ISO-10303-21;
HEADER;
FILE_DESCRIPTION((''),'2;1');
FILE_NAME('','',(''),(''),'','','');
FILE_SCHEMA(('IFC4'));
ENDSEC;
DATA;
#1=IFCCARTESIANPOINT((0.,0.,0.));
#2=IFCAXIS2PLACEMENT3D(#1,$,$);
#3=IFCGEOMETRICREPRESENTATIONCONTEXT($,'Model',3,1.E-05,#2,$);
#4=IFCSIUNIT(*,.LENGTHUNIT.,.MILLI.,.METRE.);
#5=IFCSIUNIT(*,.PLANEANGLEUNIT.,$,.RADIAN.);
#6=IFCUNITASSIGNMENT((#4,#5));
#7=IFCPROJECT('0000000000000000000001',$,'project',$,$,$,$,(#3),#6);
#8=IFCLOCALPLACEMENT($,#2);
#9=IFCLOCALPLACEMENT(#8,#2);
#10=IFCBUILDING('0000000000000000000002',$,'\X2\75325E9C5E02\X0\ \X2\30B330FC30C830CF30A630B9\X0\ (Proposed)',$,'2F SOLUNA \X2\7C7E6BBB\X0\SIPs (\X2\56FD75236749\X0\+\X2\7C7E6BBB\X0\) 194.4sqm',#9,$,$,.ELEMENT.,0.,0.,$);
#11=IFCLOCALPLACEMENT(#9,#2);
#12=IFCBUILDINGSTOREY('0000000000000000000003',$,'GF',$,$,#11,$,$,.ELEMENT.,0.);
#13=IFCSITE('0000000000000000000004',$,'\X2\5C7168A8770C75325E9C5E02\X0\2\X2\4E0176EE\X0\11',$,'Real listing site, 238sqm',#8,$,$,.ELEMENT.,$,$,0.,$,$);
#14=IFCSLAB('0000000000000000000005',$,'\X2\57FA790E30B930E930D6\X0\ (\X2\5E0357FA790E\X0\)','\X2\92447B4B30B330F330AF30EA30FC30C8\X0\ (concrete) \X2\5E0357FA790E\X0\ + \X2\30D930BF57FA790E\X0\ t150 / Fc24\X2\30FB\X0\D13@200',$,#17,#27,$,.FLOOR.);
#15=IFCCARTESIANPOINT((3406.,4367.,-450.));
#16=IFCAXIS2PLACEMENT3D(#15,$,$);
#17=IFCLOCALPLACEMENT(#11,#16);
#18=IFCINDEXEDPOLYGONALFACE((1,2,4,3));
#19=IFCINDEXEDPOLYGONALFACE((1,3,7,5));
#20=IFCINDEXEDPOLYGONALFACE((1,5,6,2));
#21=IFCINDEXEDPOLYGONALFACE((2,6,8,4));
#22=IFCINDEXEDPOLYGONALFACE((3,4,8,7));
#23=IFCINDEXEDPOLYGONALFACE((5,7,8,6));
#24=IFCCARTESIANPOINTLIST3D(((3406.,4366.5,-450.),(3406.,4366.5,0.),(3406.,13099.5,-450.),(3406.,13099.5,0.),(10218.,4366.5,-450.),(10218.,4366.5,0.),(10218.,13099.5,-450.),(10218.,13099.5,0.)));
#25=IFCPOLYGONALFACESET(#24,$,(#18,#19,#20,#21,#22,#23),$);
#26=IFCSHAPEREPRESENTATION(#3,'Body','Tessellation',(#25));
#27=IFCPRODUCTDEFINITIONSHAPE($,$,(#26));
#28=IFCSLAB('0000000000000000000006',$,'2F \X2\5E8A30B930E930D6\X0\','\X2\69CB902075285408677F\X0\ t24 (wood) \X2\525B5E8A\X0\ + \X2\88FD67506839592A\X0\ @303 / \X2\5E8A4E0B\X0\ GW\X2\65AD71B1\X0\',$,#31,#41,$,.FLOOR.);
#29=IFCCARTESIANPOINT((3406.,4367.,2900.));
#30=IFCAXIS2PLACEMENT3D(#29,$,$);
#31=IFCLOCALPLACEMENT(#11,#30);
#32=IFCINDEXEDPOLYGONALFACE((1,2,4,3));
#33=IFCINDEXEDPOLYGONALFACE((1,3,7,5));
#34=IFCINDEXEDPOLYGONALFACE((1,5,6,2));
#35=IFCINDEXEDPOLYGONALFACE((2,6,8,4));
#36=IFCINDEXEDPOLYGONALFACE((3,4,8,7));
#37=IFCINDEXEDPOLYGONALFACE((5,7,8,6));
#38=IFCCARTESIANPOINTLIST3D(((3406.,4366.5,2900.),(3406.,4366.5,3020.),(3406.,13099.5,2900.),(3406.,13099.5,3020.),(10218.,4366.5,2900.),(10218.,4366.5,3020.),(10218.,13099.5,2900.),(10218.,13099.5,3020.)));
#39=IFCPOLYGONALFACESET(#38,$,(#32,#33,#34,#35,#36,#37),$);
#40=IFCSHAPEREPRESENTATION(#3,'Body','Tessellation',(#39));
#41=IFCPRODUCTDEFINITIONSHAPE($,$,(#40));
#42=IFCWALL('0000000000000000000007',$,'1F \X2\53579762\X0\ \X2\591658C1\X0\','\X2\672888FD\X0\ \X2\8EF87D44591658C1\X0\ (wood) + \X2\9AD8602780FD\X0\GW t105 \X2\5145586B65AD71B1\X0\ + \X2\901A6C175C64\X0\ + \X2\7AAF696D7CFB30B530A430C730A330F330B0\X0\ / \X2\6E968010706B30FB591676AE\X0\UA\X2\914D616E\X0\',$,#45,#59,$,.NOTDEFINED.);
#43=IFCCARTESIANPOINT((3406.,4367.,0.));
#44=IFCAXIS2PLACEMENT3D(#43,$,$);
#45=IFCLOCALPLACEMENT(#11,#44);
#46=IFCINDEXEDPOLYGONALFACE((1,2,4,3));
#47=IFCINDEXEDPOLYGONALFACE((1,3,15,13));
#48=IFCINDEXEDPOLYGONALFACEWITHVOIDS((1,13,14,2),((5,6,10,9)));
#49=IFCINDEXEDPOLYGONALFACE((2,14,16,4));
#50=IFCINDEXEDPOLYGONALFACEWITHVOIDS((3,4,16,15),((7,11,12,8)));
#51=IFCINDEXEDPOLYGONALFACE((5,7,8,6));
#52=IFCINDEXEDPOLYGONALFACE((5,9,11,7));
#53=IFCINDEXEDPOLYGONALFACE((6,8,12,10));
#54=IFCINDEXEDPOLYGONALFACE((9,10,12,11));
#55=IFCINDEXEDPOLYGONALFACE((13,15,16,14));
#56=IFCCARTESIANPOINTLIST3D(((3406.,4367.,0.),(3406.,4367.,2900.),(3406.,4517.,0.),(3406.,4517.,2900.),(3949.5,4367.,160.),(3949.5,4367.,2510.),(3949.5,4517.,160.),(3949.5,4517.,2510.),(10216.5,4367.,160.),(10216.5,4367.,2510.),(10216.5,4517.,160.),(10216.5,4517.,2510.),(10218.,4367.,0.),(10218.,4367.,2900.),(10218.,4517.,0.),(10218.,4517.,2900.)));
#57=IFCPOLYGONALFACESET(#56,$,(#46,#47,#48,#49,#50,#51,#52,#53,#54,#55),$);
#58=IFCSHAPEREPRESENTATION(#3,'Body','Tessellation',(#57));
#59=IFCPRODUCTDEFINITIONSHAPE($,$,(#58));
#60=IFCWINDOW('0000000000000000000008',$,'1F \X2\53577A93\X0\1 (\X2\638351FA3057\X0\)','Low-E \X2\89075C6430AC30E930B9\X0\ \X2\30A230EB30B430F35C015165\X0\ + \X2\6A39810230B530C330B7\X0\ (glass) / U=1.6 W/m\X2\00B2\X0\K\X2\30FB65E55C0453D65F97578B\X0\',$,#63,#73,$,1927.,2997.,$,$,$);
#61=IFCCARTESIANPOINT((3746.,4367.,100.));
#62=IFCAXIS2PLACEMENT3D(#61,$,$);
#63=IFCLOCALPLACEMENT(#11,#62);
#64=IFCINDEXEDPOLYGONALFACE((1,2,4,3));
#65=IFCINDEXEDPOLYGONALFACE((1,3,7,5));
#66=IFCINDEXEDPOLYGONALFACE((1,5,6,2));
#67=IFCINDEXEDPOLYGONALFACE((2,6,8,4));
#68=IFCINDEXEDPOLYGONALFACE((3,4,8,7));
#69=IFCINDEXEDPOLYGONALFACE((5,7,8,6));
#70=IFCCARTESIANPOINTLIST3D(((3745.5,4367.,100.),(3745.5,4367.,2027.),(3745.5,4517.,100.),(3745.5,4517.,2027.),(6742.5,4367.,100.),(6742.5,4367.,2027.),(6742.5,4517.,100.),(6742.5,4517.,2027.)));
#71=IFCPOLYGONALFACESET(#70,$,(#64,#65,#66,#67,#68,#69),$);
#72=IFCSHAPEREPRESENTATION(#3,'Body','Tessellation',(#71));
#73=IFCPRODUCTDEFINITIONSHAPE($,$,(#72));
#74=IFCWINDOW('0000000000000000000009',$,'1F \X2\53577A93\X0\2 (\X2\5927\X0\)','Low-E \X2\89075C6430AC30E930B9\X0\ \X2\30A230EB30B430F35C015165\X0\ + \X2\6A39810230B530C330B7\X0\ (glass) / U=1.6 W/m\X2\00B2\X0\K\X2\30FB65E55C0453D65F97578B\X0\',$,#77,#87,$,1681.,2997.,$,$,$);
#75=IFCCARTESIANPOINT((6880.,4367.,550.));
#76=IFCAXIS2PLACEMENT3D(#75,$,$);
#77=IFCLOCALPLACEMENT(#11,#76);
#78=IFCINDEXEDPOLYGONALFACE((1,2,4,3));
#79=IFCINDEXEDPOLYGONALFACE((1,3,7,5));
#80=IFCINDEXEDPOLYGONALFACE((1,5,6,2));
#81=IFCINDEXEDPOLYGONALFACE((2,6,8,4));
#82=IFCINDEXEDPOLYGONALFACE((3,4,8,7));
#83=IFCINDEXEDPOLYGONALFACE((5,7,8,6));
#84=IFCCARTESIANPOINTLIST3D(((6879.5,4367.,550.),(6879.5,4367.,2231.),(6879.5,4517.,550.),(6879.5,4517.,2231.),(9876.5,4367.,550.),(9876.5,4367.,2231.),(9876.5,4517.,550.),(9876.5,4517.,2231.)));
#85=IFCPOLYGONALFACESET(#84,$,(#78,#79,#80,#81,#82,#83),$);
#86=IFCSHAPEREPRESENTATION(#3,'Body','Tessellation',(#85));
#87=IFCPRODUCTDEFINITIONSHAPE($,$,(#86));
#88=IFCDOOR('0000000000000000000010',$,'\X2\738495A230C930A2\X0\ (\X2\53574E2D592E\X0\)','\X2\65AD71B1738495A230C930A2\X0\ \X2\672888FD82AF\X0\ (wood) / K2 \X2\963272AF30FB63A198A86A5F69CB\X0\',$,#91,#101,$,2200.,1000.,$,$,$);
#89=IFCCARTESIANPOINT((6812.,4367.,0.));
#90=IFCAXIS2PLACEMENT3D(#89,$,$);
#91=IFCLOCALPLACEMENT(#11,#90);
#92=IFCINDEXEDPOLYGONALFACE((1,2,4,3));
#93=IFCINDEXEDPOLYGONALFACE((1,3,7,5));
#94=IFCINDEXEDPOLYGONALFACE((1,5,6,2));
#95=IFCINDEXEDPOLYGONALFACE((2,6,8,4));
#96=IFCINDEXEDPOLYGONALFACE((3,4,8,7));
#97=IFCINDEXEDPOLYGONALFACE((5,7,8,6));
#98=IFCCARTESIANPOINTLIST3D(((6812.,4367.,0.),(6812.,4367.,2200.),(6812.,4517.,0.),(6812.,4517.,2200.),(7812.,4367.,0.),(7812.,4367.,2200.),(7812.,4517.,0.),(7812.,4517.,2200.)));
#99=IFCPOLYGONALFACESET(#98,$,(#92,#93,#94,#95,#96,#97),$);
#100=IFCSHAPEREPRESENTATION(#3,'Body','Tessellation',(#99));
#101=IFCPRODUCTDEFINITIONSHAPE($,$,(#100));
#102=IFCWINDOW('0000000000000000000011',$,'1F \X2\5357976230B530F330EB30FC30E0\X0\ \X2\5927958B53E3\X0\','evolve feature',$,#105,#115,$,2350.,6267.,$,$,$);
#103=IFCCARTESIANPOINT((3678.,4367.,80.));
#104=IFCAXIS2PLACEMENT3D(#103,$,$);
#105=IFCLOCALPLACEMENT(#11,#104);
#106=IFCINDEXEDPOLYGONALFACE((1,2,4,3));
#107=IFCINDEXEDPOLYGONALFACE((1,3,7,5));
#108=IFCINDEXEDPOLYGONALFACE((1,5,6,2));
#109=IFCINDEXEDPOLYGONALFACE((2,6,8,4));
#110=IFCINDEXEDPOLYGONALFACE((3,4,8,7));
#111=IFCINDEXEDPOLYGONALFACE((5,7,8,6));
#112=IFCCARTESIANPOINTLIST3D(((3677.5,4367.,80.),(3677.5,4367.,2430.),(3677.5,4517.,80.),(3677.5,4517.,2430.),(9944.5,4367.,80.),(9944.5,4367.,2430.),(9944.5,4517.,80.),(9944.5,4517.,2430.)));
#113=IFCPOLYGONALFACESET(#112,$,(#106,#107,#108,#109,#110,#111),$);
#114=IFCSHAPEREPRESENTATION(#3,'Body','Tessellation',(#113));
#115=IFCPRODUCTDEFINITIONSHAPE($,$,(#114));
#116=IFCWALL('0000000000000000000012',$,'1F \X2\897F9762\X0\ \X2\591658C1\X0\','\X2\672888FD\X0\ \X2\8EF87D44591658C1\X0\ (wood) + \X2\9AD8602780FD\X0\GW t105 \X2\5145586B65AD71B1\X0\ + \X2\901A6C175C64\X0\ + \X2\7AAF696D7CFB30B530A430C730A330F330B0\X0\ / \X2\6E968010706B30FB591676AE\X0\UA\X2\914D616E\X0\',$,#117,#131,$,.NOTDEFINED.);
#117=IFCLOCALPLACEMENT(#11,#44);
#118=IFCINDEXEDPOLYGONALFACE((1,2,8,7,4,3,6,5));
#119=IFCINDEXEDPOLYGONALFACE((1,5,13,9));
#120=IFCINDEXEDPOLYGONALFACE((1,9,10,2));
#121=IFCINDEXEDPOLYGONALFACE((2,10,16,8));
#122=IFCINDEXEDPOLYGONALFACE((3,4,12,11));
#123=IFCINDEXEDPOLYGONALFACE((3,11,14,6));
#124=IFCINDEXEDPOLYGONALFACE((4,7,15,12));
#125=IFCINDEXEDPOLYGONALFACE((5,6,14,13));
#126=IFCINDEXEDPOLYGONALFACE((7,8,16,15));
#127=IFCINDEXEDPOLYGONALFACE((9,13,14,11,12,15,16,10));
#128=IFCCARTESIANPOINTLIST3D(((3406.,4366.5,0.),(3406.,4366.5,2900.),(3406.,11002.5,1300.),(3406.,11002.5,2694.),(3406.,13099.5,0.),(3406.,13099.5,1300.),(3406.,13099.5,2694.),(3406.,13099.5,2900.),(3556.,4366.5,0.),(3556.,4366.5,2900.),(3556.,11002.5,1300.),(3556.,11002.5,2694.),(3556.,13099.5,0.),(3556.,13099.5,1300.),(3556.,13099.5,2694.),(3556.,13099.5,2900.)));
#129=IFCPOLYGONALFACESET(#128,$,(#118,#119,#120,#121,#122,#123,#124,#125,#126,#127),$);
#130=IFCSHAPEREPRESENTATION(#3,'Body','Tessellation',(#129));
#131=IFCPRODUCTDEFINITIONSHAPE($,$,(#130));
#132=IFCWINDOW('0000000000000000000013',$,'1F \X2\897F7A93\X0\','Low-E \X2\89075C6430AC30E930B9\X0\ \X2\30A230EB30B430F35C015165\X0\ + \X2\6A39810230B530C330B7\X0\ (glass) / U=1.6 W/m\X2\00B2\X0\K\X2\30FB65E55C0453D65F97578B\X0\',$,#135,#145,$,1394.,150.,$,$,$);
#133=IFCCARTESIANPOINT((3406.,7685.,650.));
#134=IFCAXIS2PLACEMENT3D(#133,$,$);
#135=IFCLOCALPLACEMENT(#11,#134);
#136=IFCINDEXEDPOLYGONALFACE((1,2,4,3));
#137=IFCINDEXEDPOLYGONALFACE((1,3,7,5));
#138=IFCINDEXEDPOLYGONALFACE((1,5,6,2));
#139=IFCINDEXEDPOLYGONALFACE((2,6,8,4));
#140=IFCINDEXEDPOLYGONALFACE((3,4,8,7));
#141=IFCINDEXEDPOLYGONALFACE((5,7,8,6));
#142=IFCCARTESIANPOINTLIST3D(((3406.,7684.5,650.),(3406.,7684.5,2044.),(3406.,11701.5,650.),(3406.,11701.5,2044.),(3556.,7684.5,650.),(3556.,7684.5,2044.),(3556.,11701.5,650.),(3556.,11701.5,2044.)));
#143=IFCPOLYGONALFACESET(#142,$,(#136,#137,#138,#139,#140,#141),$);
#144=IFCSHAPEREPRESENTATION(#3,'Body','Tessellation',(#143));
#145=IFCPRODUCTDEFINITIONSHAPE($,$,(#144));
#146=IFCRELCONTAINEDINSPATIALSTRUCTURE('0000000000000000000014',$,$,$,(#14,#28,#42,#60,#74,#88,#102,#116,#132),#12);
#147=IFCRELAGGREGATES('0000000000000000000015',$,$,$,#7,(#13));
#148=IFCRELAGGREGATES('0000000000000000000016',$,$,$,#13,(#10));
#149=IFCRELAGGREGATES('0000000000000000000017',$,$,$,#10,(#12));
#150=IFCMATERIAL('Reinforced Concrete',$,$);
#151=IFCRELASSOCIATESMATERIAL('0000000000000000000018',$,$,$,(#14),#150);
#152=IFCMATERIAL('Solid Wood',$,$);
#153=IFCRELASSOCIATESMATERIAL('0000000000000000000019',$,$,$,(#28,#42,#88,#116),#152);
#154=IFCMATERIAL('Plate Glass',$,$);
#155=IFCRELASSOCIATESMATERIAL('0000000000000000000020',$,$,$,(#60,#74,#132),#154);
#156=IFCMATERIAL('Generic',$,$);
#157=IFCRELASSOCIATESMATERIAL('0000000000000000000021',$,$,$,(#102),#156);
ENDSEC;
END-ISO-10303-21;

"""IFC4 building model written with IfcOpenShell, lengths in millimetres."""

from ifc_helpers import new_model, si_unit, frame, frame_2d, origin, place, context, project, spatial, rectangle, extrude, material, element, fill, save


model = new_model("IFC4")

# Units and contexts
model_context = context("Model", 3, precision=1e-05, world=origin())
ifc_project = project(units=[si_unit("LENGTHUNIT", "METRE", prefix="MILLI"), si_unit("PLANEANGLEUNIT", "RADIAN")], contexts=[model_context])

# Site, building, storey
site_placement = place(None, origin())
site = spatial("IfcSite", under=ifc_project, at=site_placement, Name="山梨県甲府市2丁目11", ObjectType="Real listing site, 238sqm", CompositionType="ELEMENT", RefElevation=0.0)
building_placement = place(site_placement, origin())
building = spatial("IfcBuilding", under=site, at=building_placement, Name="甲府市 コートハウス (Proposed)", ObjectType="2F SOLUNA 籾殻SIPs (国産杉+籾殻) 194.4sqm", CompositionType="ELEMENT", ElevationOfRefHeight=0.0, ElevationOfTerrain=0.0)
storey_placement = place(building_placement, origin())
storey = spatial("IfcBuildingStorey", under=building, at=storey_placement, Name="GF", CompositionType="ELEMENT", Elevation=0.0)

# Slabs
ifc_material_1 = material(Name="Reinforced Concrete")
slab_1_placement = place(storey_placement, frame((3406.0, 4367.0, -450.0)))
element("IfcSlab", 1, at=slab_1_placement, inside=storey, material=ifc_material_1, Name="基礎スラブ (布基礎)", Description="鉄筋コンクリート (concrete) 布基礎 + ベタ基礎 t150 / Fc24・D13@200", PredefinedType="FLOOR", context=model_context, shape_type="SweptSolid", body=[
    extrude(rectangle(XDim=6812.0, YDim=8733.0, at=frame_2d((3406.0, 4366.0))), frame((3406.0, 4367.0, -450.0)), (0.0, 0.0, 1.0), 450.0),
])
ifc_material_2 = material(Name="Solid Wood")
slab_2_placement = place(storey_placement, frame((3406.0, 4367.0, 2900.0)))
element("IfcSlab", 2, at=slab_2_placement, inside=storey, material=ifc_material_2, Name="2F 床スラブ", Description="構造用合板 t24 (wood) 剛床 + 製材根太 @303 / 床下 GW断熱", PredefinedType="FLOOR", context=model_context, shape_type="SweptSolid", body=[
    extrude(rectangle(XDim=6812.0, YDim=8733.0, at=frame_2d((3406.0, 4366.0))), frame((3406.0, 4367.0, 2900.0)), (0.0, 0.0, 1.0), 120.0),
])

# Wall, openings, windows, door
wall_1_placement = place(storey_placement, frame((3406.0, 4367.0, 0.0)))
wall_1 = element("IfcWall", 3, at=wall_1_placement, inside=storey, material=ifc_material_2, Name="1F 南面 外壁", Description="木製 軸組外壁 (wood) + 高性能GW t105 充填断熱 + 通気層 + 窯業系サイディング / 準耐火・外皮UA配慮", PredefinedType="NOTDEFINED", context=model_context, shape_type="SweptSolid", body=[
    extrude(rectangle(XDim=6812.0, YDim=150.0, at=frame_2d((3406.0, 75.0))), frame((3406.0, 4367.0, 0.0)), (0.0, 0.0, 1.0), 2900.0),
])
opening_1_placement = place(storey_placement, frame((3746.0, 4367.0, 100.0)))
opening_1 = element("IfcOpeningElement", 4, at=opening_1_placement, cuts=wall_1, PredefinedType="NOTDEFINED", context=model_context, shape_type="SweptSolid", body=[
    extrude(rectangle(XDim=2997.0, YDim=150.0, at=frame_2d((1498.0, 75.0))), frame((3746.0, 4367.0, 100.0)), (0.0, 0.0, 1.0), 1927.0),
])
opening_2_placement = place(storey_placement, frame((6880.0, 4367.0, 550.0)))
opening_2 = element("IfcOpeningElement", 5, at=opening_2_placement, cuts=wall_1, PredefinedType="NOTDEFINED", context=model_context, shape_type="SweptSolid", body=[
    extrude(rectangle(XDim=2997.0, YDim=150.0, at=frame_2d((1498.0, 75.0))), frame((6880.0, 4367.0, 550.0)), (0.0, 0.0, 1.0), 1681.0),
])
opening_3_placement = place(storey_placement, frame((6812.0, 4367.0, 0.0)))
opening_3 = element("IfcOpeningElement", 6, at=opening_3_placement, cuts=wall_1, PredefinedType="NOTDEFINED", context=model_context, shape_type="SweptSolid", body=[
    extrude(rectangle(XDim=1000.0, YDim=150.0, at=frame_2d((500.0, 75.0))), frame((6812.0, 4367.0, 0.0)), (0.0, 0.0, 1.0), 2200.0),
])
opening_4_placement = place(storey_placement, frame((3678.0, 4367.0, 80.0)))
opening_4 = element("IfcOpeningElement", 7, at=opening_4_placement, cuts=wall_1, PredefinedType="NOTDEFINED", context=model_context, shape_type="SweptSolid", body=[
    extrude(rectangle(XDim=6267.0, YDim=150.0, at=frame_2d((3133.0, 75.0))), frame((3678.0, 4367.0, 80.0)), (0.0, 0.0, 1.0), 2350.0),
])
ifc_material_3 = material(Name="Plate Glass")
window_1_placement = place(storey_placement, frame((3746.0, 4367.0, 100.0)))
window_1 = element("IfcWindow", 8, at=window_1_placement, inside=storey, material=ifc_material_3, Name="1F 南窓1 (掃出し)", Description="Low-E 複層ガラス アルゴン封入 + 樹脂サッシ (glass) / U=1.6 W/m²K・日射取得型", OverallHeight=1927.0, OverallWidth=2997.0, context=model_context, shape_type="SweptSolid", body=[
    extrude(rectangle(XDim=2997.0, YDim=150.0, at=frame_2d((1498.0, 75.0))), frame((3746.0, 4367.0, 100.0)), (0.0, 0.0, 1.0), 1927.0),
])
fill(opening_1, window_1)
window_2_placement = place(storey_placement, frame((6880.0, 4367.0, 550.0)))
window_2 = element("IfcWindow", 9, at=window_2_placement, inside=storey, material=ifc_material_3, Name="1F 南窓2 (大)", Description="Low-E 複層ガラス アルゴン封入 + 樹脂サッシ (glass) / U=1.6 W/m²K・日射取得型", OverallHeight=1681.0, OverallWidth=2997.0, context=model_context, shape_type="SweptSolid", body=[
    extrude(rectangle(XDim=2997.0, YDim=150.0, at=frame_2d((1498.0, 75.0))), frame((6880.0, 4367.0, 550.0)), (0.0, 0.0, 1.0), 1681.0),
])
fill(opening_2, window_2)
door_placement = place(storey_placement, frame((6812.0, 4367.0, 0.0)))
door = element("IfcDoor", 10, at=door_placement, inside=storey, material=ifc_material_2, Name="玄関ドア (南中央)", Description="断熱玄関ドア 木製芯 (wood) / K2 防犯・採風機構", OverallHeight=2200.0, OverallWidth=1000.0, context=model_context, shape_type="SweptSolid", body=[
    extrude(rectangle(XDim=1000.0, YDim=150.0, at=frame_2d((500.0, 75.0))), frame((6812.0, 4367.0, 0.0)), (0.0, 0.0, 1.0), 2200.0),
])
fill(opening_3, door)
ifc_material_4 = material(Name="Generic")
window_3_placement = place(storey_placement, frame((3678.0, 4367.0, 80.0)))
window_3 = element("IfcWindow", 11, at=window_3_placement, inside=storey, material=ifc_material_4, Name="1F 南面サンルーム 大開口", Description="evolve feature", OverallHeight=2350.0, OverallWidth=6267.0, context=model_context, shape_type="SweptSolid", body=[
    extrude(rectangle(XDim=6267.0, YDim=150.0, at=frame_2d((3133.0, 75.0))), frame((3678.0, 4367.0, 80.0)), (0.0, 0.0, 1.0), 2350.0),
])
fill(opening_4, window_3)

# Wall, opening, window
wall_2_placement = place(storey_placement, frame((3406.0, 4367.0, 0.0)))
wall_2 = element("IfcWall", 12, at=wall_2_placement, inside=storey, material=ifc_material_2, Name="1F 西面 外壁", Description="木製 軸組外壁 (wood) + 高性能GW t105 充填断熱 + 通気層 + 窯業系サイディング / 準耐火・外皮UA配慮", PredefinedType="NOTDEFINED", context=model_context, shape_type="SweptSolid", body=[
    extrude(rectangle(XDim=150.0, YDim=8733.0, at=frame_2d((75.0, 4366.0))), frame((3406.0, 4367.0, 0.0)), (0.0, 0.0, 1.0), 2900.0),
])
opening_5_placement = place(storey_placement, frame((3406.0, 7685.0, 650.0)))
opening_5 = element("IfcOpeningElement", 13, at=opening_5_placement, cuts=wall_2, PredefinedType="NOTDEFINED", context=model_context, shape_type="SweptSolid", body=[
    extrude(rectangle(XDim=150.0, YDim=4017.0, at=frame_2d((75.0, 2008.0))), frame((3406.0, 7685.0, 650.0)), (0.0, 0.0, 1.0), 1394.0),
])
window_4_placement = place(storey_placement, frame((3406.0, 7685.0, 650.0)))
window_4 = element("IfcWindow", 14, at=window_4_placement, inside=storey, material=ifc_material_3, Name="1F 西窓", Description="Low-E 複層ガラス アルゴン封入 + 樹脂サッシ (glass) / U=1.6 W/m²K・日射取得型", OverallHeight=1394.0, OverallWidth=150.0, context=model_context, shape_type="SweptSolid", body=[
    extrude(rectangle(XDim=150.0, YDim=4017.0, at=frame_2d((75.0, 2008.0))), frame((3406.0, 7685.0, 650.0)), (0.0, 0.0, 1.0), 1394.0),
])
fill(opening_5, window_4)

save(model, "model.ifc")
